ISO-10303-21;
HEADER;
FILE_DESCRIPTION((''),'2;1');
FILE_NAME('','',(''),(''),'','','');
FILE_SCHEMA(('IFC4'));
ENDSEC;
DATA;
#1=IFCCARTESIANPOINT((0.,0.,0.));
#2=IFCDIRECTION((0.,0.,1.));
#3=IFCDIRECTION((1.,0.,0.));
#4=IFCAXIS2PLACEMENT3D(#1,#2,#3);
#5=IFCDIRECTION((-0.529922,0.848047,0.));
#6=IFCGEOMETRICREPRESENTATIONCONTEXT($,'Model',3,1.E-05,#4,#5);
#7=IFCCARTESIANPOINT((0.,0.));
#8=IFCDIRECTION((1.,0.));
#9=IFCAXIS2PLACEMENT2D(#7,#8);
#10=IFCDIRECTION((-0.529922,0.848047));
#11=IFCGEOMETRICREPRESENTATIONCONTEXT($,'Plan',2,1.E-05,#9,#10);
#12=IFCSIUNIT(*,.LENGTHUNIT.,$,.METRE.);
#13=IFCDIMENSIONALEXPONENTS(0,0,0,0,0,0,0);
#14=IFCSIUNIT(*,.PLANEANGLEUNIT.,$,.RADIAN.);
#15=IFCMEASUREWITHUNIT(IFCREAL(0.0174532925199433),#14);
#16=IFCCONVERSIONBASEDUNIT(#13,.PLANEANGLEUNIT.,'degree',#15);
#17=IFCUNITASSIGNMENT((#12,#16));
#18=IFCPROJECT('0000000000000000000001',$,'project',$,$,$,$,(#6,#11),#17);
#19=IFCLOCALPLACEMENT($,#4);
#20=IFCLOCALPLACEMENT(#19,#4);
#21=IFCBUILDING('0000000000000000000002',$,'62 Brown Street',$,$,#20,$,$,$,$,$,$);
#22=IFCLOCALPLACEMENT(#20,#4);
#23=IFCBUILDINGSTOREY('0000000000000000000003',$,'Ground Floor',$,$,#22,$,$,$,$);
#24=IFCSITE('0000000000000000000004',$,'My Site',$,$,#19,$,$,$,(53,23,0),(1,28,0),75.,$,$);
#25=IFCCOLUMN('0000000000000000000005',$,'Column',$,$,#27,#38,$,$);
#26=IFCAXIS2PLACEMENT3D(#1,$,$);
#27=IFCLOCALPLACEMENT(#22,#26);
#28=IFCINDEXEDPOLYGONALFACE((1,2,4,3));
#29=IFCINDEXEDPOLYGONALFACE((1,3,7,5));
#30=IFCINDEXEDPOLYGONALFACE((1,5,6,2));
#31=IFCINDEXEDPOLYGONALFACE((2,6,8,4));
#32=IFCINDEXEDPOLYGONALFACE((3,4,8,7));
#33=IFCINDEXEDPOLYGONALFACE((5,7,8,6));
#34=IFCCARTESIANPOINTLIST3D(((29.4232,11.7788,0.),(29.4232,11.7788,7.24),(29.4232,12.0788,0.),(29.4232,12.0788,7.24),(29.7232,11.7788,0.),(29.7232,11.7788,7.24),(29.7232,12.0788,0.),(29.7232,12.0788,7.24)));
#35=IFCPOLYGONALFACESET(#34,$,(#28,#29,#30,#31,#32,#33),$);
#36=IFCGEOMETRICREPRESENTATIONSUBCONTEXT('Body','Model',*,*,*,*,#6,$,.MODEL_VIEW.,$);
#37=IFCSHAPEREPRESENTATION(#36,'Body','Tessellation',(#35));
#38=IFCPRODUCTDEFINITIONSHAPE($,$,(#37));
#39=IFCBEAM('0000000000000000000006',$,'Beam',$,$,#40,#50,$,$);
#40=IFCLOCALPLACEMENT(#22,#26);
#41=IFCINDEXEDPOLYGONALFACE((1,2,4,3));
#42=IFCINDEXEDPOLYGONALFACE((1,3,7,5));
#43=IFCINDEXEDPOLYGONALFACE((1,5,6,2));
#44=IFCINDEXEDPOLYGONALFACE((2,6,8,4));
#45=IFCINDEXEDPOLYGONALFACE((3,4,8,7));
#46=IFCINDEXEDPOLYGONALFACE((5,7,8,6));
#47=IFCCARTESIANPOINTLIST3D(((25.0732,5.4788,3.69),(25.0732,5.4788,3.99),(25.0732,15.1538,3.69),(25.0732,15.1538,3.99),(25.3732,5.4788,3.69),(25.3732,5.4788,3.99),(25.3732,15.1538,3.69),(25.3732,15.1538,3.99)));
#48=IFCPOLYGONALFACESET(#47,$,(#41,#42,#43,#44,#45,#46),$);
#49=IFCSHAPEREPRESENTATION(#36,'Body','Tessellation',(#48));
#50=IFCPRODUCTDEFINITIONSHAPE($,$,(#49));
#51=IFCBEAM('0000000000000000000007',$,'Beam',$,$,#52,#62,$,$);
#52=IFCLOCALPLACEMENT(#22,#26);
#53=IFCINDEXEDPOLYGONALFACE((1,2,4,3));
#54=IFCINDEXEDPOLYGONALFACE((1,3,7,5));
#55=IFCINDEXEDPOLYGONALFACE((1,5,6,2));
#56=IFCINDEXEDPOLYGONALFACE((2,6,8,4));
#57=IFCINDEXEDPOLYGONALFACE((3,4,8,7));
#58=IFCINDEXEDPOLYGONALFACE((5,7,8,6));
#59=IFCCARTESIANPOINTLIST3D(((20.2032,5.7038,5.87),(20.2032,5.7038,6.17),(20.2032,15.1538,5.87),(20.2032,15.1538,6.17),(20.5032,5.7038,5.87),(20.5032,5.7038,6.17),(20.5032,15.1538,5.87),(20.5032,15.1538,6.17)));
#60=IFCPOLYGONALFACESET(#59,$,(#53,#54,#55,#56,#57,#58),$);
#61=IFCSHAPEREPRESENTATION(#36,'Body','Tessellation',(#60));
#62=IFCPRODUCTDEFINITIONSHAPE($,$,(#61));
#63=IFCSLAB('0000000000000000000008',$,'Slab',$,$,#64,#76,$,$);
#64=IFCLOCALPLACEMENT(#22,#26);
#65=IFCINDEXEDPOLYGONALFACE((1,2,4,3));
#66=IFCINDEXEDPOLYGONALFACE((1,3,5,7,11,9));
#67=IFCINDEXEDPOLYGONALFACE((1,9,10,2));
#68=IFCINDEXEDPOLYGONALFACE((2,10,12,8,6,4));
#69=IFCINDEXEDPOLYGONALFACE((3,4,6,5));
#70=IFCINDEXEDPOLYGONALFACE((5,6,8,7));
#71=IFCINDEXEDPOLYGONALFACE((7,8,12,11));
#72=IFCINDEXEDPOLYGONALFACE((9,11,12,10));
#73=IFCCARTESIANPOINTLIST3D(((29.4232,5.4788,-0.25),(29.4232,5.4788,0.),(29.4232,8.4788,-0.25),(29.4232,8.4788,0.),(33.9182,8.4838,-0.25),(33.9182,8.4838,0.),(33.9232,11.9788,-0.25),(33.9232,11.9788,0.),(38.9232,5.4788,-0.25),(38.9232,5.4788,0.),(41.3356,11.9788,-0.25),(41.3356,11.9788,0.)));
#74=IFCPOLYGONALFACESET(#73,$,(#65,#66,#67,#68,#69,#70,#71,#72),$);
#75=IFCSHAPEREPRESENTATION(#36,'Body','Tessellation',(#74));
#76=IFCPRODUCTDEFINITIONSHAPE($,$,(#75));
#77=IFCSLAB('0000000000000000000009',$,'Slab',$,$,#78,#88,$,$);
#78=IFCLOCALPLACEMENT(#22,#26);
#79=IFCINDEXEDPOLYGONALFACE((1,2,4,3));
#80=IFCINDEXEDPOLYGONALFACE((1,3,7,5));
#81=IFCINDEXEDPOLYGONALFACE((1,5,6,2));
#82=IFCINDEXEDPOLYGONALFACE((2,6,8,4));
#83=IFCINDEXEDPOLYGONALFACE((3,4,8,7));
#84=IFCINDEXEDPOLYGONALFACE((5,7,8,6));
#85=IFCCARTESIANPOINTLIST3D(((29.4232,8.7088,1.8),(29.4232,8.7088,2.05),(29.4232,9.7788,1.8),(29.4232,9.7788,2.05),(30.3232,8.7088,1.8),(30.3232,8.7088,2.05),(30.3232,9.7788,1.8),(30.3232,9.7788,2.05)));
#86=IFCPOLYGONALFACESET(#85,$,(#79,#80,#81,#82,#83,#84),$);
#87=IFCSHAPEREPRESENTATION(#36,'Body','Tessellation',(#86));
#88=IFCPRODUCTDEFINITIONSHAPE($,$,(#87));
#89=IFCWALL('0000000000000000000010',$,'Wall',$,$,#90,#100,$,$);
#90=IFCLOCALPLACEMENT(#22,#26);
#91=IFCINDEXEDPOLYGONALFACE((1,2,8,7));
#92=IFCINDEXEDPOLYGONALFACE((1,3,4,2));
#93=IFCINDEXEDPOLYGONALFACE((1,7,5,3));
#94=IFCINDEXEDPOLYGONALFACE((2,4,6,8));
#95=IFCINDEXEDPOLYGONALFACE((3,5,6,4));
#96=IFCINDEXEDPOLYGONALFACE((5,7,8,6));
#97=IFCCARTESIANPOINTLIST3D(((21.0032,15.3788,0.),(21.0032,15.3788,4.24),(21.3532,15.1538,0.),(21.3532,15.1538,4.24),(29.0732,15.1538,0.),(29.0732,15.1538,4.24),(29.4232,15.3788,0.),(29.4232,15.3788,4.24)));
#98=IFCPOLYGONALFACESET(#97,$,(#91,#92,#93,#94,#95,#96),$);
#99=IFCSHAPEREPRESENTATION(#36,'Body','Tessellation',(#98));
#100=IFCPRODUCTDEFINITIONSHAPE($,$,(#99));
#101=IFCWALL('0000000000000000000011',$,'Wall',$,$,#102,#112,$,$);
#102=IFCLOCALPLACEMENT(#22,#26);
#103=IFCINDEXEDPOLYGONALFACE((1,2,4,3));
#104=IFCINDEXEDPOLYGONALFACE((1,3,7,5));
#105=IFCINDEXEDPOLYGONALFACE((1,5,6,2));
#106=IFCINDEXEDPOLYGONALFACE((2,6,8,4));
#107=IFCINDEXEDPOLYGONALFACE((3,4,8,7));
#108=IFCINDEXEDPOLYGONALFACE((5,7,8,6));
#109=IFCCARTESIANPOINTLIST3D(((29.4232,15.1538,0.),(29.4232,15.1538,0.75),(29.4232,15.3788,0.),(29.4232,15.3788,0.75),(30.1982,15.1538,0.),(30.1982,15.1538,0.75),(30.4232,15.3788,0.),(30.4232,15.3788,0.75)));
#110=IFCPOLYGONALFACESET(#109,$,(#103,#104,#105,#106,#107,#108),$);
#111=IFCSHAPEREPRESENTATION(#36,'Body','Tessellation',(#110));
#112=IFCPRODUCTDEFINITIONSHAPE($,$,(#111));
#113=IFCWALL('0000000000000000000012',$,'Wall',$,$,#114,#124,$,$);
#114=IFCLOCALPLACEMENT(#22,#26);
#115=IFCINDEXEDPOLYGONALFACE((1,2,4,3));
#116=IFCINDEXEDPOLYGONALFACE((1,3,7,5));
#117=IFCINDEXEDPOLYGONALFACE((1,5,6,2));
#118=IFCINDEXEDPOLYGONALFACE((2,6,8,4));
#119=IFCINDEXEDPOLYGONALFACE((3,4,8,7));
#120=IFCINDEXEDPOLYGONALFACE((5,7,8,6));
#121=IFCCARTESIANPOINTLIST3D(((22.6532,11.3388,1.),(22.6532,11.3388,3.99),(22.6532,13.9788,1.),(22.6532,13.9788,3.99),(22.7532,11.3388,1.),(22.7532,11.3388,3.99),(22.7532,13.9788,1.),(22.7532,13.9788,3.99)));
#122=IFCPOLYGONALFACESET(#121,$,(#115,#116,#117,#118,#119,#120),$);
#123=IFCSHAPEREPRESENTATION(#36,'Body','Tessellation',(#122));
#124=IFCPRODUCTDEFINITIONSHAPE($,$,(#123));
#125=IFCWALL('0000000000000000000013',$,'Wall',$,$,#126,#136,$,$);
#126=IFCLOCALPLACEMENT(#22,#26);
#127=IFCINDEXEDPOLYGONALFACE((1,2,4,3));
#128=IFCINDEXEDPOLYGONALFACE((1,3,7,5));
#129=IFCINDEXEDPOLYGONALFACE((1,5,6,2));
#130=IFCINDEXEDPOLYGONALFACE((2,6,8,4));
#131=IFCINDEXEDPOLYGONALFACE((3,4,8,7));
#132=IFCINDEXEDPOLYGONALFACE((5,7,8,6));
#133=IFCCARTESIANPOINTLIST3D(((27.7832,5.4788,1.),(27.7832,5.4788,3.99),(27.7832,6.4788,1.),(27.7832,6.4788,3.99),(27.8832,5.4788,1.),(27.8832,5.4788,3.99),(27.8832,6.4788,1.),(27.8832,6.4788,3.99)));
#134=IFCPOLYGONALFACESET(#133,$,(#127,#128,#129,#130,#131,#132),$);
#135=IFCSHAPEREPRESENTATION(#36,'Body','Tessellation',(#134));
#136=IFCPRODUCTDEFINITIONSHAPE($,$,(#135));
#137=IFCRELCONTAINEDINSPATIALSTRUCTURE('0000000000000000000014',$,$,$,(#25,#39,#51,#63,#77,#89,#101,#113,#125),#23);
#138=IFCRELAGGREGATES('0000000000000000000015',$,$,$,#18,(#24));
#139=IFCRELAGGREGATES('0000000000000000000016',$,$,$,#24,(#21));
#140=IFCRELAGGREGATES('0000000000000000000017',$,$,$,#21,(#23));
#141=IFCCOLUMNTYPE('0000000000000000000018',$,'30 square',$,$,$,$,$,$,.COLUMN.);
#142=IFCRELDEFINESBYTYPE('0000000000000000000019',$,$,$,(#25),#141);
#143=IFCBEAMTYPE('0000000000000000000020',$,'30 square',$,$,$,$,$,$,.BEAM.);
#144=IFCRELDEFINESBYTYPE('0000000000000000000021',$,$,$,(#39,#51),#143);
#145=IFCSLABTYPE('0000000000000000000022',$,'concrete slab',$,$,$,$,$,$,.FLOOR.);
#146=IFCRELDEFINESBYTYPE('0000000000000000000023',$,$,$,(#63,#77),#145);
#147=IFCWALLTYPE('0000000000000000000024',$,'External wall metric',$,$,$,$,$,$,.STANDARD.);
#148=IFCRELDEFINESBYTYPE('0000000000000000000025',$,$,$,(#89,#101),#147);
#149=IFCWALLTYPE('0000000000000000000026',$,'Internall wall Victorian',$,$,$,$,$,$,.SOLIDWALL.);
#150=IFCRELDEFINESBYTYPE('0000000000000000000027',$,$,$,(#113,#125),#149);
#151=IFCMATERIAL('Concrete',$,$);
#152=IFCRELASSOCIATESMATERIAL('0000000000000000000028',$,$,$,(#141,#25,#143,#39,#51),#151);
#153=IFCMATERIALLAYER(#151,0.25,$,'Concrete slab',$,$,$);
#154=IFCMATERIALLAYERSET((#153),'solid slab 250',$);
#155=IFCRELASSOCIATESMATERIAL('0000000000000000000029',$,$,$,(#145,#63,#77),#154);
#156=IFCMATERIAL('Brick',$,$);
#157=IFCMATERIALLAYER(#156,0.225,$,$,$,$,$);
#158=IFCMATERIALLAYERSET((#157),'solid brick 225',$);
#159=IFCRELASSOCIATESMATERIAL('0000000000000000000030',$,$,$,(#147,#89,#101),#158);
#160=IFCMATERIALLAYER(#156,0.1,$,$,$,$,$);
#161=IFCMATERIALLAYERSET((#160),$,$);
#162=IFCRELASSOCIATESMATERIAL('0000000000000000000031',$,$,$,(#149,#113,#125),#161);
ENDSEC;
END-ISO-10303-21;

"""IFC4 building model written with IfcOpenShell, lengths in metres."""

from ifc_helpers import new_model, entity, si_unit, converted_unit, direction, frame, origin_with_axes, origin_2d_with_axis, place, context, subcontext, project, spatial, line, indexed_curve, rectangle, outline, extrude, clip, halfspace, material, layer, layer_set, layer_usage, material_profile, profile_set, profile_usage, type_object, element, save


model = new_model("IFC4")

# Units and contexts
model_context = context("Model", 3, precision=1e-05, world=origin_with_axes(), true_north=direction((-0.529922, 0.848047, 0.0)))
plan_context = context("Plan", 2, precision=1e-05, world=origin_2d_with_axis(), true_north=direction((-0.529922, 0.848047)))
body_context_1 = subcontext(model_context, "Body", "Model", "MODEL_VIEW")
ifc_project = project(units=[si_unit("LENGTHUNIT", "METRE"), converted_unit("PLANEANGLEUNIT", "degree", entity("IfcReal", 0.0174532925199433), si_unit("PLANEANGLEUNIT", "RADIAN"), dimensions=[0, 0, 0, 0, 0, 0, 0])], contexts=[model_context, plan_context])

# Site, building, storey
site_placement = place(None, origin_with_axes())
site = spatial("IfcSite", under=ifc_project, at=site_placement, Name="My Site", RefLatitude=(53, 23, 0), RefLongitude=(1, 28, 0), RefElevation=75.0)
building_placement = place(site_placement, origin_with_axes())
building = spatial("IfcBuilding", under=site, at=building_placement, Name="62 Brown Street")
storey_placement = place(building_placement, origin_with_axes())
storey = spatial("IfcBuildingStorey", under=building, at=storey_placement, Name="Ground Floor")

# Column
ifc_material_1 = material(Name="Concrete")
ifc_material_profile_1 = material_profile(ifc_material_1, rectangle(XDim=0.3, YDim=0.3))
ifc_profile_set_1 = profile_set([ifc_material_profile_1])
ifc_profile_usage_1 = profile_usage(ifc_profile_set_1, cardinal=5)
column_type = type_object("IfcColumnType", Name="30 square", PredefinedType="COLUMN", material=ifc_profile_set_1)
column_1_placement = place(storey_placement, frame((29.5732, 11.9288, 0.0), z_axis=(0.0, 0.0, 1.0), x_axis=(1.0, 0.0, 0.0)))
element("IfcColumn", 1, at=column_1_placement, inside=storey, type_object=column_type, material=ifc_profile_usage_1, Name="Column", context=body_context_1, shape_type="SweptSolid", body=[
    extrude(rectangle(XDim=0.3, YDim=0.3), origin_with_axes(), (0.0, 0.0, 1.0), 7.24),
])

# Beams
ifc_material_profile_2 = material_profile(ifc_material_1, rectangle(XDim=0.3, YDim=0.3))
ifc_profile_set_2 = profile_set([ifc_material_profile_2])
ifc_profile_usage_2 = profile_usage(ifc_profile_set_2, cardinal=5)
beam_type = type_object("IfcBeamType", Name="30 square", PredefinedType="BEAM", material=ifc_profile_set_2)
beam_1_placement = place(storey_placement, frame((25.2232, 5.4788, 3.84), z_axis=(0.0, 1.0, 0.0), x_axis=(-1.0, 0.0, 0.0)))
element("IfcBeam", 2, at=beam_1_placement, inside=storey, type_object=beam_type, material=ifc_profile_usage_2, Name="Beam", context=body_context_1, shape_type="SweptSolid", body=[
    extrude(rectangle(XDim=0.3, YDim=0.3), origin_with_axes(), (0.0, 0.0, 1.0), 9.675),
])
ifc_profile_usage_3 = profile_usage(ifc_profile_set_2, cardinal=5)
beam_2_placement = place(storey_placement, frame((20.3532, 15.1538, 6.02), z_axis=(0.0, -1.0, 0.0), x_axis=(1.0, 0.0, 0.0)))
element("IfcBeam", 3, at=beam_2_placement, inside=storey, type_object=beam_type, material=ifc_profile_usage_3, Name="Beam", context=body_context_1, shape_type="SweptSolid", body=[
    extrude(rectangle(XDim=0.3, YDim=0.3), origin_with_axes(), (0.0, 0.0, 1.0), 9.45),
])

# Slabs
ifc_layer_1 = layer(ifc_material_1, 0.25, Name="Concrete slab")
ifc_layer_set_1 = layer_set([ifc_layer_1], Name="solid slab 250")
ifc_layer_usage_1 = layer_usage(ifc_layer_set_1, "AXIS3", "POSITIVE", 0.0)
slab_type = type_object("IfcSlabType", Name="concrete slab", PredefinedType="FLOOR", material=ifc_layer_set_1)
slab_1_placement = place(storey_placement, frame((29.4232, 5.4788, -0.25), z_axis=(0.0, 0.0, 1.0), x_axis=(1.0, 0.0, 0.0)))
element("IfcSlab", 4, at=slab_1_placement, inside=storey, type_object=slab_type, material=ifc_layer_usage_1, Name="Slab", context=body_context_1, shape_type="SweptSolid", body=[
    extrude(outline(indexed_curve([(0.0, 0.0), (9.5, 0.0), (11.9124, 6.5), (0.0, 3.0), (4.5, 6.5), (4.495, 3.005)], segments=[line(1, 2), line(2, 3), line(3, 5), line(5, 6), line(6, 4), line(4, 1)], self_intersect=False)), None, (0.0, 0.0, 1.0), 0.25),
])
ifc_layer_usage_2 = layer_usage(ifc_layer_set_1, "AXIS3", "POSITIVE", 0.0)
slab_2_placement = place(storey_placement, frame((29.4232, 8.7088, 1.8), z_axis=(0.0, 0.0, 1.0), x_axis=(1.0, 0.0, 0.0)))
element("IfcSlab", 5, at=slab_2_placement, inside=storey, type_object=slab_type, material=ifc_layer_usage_2, Name="Slab", context=body_context_1, shape_type="SweptSolid", body=[
    extrude(outline(indexed_curve([(0.9, 1.07), (0.9, 0.0), (0.0, 0.0), (0.0, 1.07)], segments=[line(3, 2), line(2, 1), line(1, 4), line(4, 3)], self_intersect=False)), None, (0.0, 0.0, 1.0), 0.25),
])

# Walls
ifc_material_2 = material(Name="Brick")
ifc_layer_2 = layer(ifc_material_2, 0.225)
ifc_layer_set_2 = layer_set([ifc_layer_2], Name="solid brick 225")
wall_type_1 = type_object("IfcWallType", Name="External wall metric", PredefinedType="STANDARD", material=ifc_layer_set_2)
ifc_layer_usage_3 = layer_usage(ifc_layer_set_2, "AXIS2", "POSITIVE", 0.0)
wall_1_placement = place(storey_placement, frame((29.4232, 15.3788, 0.0), z_axis=(0.0, 0.0, 1.0), x_axis=(-1.0, 0.0, 0.0)))
element("IfcWall", 6, at=wall_1_placement, inside=storey, type_object=wall_type_1, material=ifc_layer_usage_3, Name="Wall", context=body_context_1, shape_type="Clipping", body=[
    clip(clip(extrude(outline(indexed_curve([(0.0, 0.0), (0.0, 0.225), (8.42, 0.225), (8.42, 0.0), (0.0, 0.0)], self_intersect=False)), origin_with_axes(), (0.0, 0.0, 1.0), 4.24), halfspace(frame((8.42, 0.0, 0.0), z_axis=(0.540756, 0.841179, 0.0), x_axis=(-0.841179, 0.540756, 0.0)), False)), halfspace(frame((0.0, 0.0, 0.0), z_axis=(-0.540758, 0.841178, 0.0), x_axis=(0.841178, 0.540758, 0.0)), False)),
])
ifc_layer_usage_4 = layer_usage(ifc_layer_set_2, "AXIS2", "POSITIVE", 0.0)
wall_2_placement = place(storey_placement, frame((30.4232, 15.3788, 0.0), z_axis=(0.0, 0.0, 1.0), x_axis=(-1.0, 0.0, 0.0)))
element("IfcWall", 7, at=wall_2_placement, inside=storey, type_object=wall_type_1, material=ifc_layer_usage_4, Name="Wall", context=body_context_1, shape_type="Clipping", body=[
    clip(extrude(outline(indexed_curve([(0.0, 0.0), (0.0, 0.225), (1.0, 0.225), (1.0, 0.0), (0.0, 0.0)], self_intersect=False)), origin_with_axes(), (0.0, 0.0, 1.0), 0.75), halfspace(frame((0.0, 0.0, 0.0), z_axis=(-0.707107, 0.707107, 0.0), x_axis=(0.707107, 0.707107, 0.0)), False)),
])
ifc_layer_3 = layer(ifc_material_2, 0.1)
ifc_layer_set_3 = layer_set([ifc_layer_3])
ifc_layer_usage_5 = layer_usage(ifc_layer_set_3, "AXIS2", "POSITIVE", 0.0)
wall_type_2 = type_object("IfcWallType", Name="Internall wall Victorian", PredefinedType="SOLIDWALL", material=ifc_layer_set_3)
wall_3_placement = place(storey_placement, frame((22.7532, 11.3388, 1.0), z_axis=(0.0, 0.0, 1.0), x_axis=(0.0, 1.0, 0.0)))
element("IfcWall", 8, at=wall_3_placement, inside=storey, type_object=wall_type_2, material=ifc_layer_usage_5, Name="Wall", context=body_context_1, shape_type="SweptSolid", body=[
    extrude(outline(indexed_curve([(0.0, 0.0), (0.0, 0.1), (2.64, 0.1), (2.64, 0.0), (0.0, 0.0)], self_intersect=False)), origin_with_axes(), (0.0, 0.0, 1.0), 2.99),
])
ifc_layer_usage_6 = layer_usage(ifc_layer_set_3, "AXIS2", "POSITIVE", 0.0)
wall_4_placement = place(storey_placement, frame((27.8832, 5.4788, 1.0), z_axis=(0.0, 0.0, 1.0), x_axis=(0.0, 1.0, 0.0)))
element("IfcWall", 9, at=wall_4_placement, inside=storey, type_object=wall_type_2, material=ifc_layer_usage_6, Name="Wall", context=body_context_1, shape_type="SweptSolid", body=[
    extrude(outline(indexed_curve([(0.0, 0.0), (0.0, 0.1), (1.0, 0.1), (1.0, 0.0), (0.0, 0.0)], self_intersect=False)), origin_with_axes(), (0.0, 0.0, 1.0), 2.99),
])

save(model, "model.ifc")
